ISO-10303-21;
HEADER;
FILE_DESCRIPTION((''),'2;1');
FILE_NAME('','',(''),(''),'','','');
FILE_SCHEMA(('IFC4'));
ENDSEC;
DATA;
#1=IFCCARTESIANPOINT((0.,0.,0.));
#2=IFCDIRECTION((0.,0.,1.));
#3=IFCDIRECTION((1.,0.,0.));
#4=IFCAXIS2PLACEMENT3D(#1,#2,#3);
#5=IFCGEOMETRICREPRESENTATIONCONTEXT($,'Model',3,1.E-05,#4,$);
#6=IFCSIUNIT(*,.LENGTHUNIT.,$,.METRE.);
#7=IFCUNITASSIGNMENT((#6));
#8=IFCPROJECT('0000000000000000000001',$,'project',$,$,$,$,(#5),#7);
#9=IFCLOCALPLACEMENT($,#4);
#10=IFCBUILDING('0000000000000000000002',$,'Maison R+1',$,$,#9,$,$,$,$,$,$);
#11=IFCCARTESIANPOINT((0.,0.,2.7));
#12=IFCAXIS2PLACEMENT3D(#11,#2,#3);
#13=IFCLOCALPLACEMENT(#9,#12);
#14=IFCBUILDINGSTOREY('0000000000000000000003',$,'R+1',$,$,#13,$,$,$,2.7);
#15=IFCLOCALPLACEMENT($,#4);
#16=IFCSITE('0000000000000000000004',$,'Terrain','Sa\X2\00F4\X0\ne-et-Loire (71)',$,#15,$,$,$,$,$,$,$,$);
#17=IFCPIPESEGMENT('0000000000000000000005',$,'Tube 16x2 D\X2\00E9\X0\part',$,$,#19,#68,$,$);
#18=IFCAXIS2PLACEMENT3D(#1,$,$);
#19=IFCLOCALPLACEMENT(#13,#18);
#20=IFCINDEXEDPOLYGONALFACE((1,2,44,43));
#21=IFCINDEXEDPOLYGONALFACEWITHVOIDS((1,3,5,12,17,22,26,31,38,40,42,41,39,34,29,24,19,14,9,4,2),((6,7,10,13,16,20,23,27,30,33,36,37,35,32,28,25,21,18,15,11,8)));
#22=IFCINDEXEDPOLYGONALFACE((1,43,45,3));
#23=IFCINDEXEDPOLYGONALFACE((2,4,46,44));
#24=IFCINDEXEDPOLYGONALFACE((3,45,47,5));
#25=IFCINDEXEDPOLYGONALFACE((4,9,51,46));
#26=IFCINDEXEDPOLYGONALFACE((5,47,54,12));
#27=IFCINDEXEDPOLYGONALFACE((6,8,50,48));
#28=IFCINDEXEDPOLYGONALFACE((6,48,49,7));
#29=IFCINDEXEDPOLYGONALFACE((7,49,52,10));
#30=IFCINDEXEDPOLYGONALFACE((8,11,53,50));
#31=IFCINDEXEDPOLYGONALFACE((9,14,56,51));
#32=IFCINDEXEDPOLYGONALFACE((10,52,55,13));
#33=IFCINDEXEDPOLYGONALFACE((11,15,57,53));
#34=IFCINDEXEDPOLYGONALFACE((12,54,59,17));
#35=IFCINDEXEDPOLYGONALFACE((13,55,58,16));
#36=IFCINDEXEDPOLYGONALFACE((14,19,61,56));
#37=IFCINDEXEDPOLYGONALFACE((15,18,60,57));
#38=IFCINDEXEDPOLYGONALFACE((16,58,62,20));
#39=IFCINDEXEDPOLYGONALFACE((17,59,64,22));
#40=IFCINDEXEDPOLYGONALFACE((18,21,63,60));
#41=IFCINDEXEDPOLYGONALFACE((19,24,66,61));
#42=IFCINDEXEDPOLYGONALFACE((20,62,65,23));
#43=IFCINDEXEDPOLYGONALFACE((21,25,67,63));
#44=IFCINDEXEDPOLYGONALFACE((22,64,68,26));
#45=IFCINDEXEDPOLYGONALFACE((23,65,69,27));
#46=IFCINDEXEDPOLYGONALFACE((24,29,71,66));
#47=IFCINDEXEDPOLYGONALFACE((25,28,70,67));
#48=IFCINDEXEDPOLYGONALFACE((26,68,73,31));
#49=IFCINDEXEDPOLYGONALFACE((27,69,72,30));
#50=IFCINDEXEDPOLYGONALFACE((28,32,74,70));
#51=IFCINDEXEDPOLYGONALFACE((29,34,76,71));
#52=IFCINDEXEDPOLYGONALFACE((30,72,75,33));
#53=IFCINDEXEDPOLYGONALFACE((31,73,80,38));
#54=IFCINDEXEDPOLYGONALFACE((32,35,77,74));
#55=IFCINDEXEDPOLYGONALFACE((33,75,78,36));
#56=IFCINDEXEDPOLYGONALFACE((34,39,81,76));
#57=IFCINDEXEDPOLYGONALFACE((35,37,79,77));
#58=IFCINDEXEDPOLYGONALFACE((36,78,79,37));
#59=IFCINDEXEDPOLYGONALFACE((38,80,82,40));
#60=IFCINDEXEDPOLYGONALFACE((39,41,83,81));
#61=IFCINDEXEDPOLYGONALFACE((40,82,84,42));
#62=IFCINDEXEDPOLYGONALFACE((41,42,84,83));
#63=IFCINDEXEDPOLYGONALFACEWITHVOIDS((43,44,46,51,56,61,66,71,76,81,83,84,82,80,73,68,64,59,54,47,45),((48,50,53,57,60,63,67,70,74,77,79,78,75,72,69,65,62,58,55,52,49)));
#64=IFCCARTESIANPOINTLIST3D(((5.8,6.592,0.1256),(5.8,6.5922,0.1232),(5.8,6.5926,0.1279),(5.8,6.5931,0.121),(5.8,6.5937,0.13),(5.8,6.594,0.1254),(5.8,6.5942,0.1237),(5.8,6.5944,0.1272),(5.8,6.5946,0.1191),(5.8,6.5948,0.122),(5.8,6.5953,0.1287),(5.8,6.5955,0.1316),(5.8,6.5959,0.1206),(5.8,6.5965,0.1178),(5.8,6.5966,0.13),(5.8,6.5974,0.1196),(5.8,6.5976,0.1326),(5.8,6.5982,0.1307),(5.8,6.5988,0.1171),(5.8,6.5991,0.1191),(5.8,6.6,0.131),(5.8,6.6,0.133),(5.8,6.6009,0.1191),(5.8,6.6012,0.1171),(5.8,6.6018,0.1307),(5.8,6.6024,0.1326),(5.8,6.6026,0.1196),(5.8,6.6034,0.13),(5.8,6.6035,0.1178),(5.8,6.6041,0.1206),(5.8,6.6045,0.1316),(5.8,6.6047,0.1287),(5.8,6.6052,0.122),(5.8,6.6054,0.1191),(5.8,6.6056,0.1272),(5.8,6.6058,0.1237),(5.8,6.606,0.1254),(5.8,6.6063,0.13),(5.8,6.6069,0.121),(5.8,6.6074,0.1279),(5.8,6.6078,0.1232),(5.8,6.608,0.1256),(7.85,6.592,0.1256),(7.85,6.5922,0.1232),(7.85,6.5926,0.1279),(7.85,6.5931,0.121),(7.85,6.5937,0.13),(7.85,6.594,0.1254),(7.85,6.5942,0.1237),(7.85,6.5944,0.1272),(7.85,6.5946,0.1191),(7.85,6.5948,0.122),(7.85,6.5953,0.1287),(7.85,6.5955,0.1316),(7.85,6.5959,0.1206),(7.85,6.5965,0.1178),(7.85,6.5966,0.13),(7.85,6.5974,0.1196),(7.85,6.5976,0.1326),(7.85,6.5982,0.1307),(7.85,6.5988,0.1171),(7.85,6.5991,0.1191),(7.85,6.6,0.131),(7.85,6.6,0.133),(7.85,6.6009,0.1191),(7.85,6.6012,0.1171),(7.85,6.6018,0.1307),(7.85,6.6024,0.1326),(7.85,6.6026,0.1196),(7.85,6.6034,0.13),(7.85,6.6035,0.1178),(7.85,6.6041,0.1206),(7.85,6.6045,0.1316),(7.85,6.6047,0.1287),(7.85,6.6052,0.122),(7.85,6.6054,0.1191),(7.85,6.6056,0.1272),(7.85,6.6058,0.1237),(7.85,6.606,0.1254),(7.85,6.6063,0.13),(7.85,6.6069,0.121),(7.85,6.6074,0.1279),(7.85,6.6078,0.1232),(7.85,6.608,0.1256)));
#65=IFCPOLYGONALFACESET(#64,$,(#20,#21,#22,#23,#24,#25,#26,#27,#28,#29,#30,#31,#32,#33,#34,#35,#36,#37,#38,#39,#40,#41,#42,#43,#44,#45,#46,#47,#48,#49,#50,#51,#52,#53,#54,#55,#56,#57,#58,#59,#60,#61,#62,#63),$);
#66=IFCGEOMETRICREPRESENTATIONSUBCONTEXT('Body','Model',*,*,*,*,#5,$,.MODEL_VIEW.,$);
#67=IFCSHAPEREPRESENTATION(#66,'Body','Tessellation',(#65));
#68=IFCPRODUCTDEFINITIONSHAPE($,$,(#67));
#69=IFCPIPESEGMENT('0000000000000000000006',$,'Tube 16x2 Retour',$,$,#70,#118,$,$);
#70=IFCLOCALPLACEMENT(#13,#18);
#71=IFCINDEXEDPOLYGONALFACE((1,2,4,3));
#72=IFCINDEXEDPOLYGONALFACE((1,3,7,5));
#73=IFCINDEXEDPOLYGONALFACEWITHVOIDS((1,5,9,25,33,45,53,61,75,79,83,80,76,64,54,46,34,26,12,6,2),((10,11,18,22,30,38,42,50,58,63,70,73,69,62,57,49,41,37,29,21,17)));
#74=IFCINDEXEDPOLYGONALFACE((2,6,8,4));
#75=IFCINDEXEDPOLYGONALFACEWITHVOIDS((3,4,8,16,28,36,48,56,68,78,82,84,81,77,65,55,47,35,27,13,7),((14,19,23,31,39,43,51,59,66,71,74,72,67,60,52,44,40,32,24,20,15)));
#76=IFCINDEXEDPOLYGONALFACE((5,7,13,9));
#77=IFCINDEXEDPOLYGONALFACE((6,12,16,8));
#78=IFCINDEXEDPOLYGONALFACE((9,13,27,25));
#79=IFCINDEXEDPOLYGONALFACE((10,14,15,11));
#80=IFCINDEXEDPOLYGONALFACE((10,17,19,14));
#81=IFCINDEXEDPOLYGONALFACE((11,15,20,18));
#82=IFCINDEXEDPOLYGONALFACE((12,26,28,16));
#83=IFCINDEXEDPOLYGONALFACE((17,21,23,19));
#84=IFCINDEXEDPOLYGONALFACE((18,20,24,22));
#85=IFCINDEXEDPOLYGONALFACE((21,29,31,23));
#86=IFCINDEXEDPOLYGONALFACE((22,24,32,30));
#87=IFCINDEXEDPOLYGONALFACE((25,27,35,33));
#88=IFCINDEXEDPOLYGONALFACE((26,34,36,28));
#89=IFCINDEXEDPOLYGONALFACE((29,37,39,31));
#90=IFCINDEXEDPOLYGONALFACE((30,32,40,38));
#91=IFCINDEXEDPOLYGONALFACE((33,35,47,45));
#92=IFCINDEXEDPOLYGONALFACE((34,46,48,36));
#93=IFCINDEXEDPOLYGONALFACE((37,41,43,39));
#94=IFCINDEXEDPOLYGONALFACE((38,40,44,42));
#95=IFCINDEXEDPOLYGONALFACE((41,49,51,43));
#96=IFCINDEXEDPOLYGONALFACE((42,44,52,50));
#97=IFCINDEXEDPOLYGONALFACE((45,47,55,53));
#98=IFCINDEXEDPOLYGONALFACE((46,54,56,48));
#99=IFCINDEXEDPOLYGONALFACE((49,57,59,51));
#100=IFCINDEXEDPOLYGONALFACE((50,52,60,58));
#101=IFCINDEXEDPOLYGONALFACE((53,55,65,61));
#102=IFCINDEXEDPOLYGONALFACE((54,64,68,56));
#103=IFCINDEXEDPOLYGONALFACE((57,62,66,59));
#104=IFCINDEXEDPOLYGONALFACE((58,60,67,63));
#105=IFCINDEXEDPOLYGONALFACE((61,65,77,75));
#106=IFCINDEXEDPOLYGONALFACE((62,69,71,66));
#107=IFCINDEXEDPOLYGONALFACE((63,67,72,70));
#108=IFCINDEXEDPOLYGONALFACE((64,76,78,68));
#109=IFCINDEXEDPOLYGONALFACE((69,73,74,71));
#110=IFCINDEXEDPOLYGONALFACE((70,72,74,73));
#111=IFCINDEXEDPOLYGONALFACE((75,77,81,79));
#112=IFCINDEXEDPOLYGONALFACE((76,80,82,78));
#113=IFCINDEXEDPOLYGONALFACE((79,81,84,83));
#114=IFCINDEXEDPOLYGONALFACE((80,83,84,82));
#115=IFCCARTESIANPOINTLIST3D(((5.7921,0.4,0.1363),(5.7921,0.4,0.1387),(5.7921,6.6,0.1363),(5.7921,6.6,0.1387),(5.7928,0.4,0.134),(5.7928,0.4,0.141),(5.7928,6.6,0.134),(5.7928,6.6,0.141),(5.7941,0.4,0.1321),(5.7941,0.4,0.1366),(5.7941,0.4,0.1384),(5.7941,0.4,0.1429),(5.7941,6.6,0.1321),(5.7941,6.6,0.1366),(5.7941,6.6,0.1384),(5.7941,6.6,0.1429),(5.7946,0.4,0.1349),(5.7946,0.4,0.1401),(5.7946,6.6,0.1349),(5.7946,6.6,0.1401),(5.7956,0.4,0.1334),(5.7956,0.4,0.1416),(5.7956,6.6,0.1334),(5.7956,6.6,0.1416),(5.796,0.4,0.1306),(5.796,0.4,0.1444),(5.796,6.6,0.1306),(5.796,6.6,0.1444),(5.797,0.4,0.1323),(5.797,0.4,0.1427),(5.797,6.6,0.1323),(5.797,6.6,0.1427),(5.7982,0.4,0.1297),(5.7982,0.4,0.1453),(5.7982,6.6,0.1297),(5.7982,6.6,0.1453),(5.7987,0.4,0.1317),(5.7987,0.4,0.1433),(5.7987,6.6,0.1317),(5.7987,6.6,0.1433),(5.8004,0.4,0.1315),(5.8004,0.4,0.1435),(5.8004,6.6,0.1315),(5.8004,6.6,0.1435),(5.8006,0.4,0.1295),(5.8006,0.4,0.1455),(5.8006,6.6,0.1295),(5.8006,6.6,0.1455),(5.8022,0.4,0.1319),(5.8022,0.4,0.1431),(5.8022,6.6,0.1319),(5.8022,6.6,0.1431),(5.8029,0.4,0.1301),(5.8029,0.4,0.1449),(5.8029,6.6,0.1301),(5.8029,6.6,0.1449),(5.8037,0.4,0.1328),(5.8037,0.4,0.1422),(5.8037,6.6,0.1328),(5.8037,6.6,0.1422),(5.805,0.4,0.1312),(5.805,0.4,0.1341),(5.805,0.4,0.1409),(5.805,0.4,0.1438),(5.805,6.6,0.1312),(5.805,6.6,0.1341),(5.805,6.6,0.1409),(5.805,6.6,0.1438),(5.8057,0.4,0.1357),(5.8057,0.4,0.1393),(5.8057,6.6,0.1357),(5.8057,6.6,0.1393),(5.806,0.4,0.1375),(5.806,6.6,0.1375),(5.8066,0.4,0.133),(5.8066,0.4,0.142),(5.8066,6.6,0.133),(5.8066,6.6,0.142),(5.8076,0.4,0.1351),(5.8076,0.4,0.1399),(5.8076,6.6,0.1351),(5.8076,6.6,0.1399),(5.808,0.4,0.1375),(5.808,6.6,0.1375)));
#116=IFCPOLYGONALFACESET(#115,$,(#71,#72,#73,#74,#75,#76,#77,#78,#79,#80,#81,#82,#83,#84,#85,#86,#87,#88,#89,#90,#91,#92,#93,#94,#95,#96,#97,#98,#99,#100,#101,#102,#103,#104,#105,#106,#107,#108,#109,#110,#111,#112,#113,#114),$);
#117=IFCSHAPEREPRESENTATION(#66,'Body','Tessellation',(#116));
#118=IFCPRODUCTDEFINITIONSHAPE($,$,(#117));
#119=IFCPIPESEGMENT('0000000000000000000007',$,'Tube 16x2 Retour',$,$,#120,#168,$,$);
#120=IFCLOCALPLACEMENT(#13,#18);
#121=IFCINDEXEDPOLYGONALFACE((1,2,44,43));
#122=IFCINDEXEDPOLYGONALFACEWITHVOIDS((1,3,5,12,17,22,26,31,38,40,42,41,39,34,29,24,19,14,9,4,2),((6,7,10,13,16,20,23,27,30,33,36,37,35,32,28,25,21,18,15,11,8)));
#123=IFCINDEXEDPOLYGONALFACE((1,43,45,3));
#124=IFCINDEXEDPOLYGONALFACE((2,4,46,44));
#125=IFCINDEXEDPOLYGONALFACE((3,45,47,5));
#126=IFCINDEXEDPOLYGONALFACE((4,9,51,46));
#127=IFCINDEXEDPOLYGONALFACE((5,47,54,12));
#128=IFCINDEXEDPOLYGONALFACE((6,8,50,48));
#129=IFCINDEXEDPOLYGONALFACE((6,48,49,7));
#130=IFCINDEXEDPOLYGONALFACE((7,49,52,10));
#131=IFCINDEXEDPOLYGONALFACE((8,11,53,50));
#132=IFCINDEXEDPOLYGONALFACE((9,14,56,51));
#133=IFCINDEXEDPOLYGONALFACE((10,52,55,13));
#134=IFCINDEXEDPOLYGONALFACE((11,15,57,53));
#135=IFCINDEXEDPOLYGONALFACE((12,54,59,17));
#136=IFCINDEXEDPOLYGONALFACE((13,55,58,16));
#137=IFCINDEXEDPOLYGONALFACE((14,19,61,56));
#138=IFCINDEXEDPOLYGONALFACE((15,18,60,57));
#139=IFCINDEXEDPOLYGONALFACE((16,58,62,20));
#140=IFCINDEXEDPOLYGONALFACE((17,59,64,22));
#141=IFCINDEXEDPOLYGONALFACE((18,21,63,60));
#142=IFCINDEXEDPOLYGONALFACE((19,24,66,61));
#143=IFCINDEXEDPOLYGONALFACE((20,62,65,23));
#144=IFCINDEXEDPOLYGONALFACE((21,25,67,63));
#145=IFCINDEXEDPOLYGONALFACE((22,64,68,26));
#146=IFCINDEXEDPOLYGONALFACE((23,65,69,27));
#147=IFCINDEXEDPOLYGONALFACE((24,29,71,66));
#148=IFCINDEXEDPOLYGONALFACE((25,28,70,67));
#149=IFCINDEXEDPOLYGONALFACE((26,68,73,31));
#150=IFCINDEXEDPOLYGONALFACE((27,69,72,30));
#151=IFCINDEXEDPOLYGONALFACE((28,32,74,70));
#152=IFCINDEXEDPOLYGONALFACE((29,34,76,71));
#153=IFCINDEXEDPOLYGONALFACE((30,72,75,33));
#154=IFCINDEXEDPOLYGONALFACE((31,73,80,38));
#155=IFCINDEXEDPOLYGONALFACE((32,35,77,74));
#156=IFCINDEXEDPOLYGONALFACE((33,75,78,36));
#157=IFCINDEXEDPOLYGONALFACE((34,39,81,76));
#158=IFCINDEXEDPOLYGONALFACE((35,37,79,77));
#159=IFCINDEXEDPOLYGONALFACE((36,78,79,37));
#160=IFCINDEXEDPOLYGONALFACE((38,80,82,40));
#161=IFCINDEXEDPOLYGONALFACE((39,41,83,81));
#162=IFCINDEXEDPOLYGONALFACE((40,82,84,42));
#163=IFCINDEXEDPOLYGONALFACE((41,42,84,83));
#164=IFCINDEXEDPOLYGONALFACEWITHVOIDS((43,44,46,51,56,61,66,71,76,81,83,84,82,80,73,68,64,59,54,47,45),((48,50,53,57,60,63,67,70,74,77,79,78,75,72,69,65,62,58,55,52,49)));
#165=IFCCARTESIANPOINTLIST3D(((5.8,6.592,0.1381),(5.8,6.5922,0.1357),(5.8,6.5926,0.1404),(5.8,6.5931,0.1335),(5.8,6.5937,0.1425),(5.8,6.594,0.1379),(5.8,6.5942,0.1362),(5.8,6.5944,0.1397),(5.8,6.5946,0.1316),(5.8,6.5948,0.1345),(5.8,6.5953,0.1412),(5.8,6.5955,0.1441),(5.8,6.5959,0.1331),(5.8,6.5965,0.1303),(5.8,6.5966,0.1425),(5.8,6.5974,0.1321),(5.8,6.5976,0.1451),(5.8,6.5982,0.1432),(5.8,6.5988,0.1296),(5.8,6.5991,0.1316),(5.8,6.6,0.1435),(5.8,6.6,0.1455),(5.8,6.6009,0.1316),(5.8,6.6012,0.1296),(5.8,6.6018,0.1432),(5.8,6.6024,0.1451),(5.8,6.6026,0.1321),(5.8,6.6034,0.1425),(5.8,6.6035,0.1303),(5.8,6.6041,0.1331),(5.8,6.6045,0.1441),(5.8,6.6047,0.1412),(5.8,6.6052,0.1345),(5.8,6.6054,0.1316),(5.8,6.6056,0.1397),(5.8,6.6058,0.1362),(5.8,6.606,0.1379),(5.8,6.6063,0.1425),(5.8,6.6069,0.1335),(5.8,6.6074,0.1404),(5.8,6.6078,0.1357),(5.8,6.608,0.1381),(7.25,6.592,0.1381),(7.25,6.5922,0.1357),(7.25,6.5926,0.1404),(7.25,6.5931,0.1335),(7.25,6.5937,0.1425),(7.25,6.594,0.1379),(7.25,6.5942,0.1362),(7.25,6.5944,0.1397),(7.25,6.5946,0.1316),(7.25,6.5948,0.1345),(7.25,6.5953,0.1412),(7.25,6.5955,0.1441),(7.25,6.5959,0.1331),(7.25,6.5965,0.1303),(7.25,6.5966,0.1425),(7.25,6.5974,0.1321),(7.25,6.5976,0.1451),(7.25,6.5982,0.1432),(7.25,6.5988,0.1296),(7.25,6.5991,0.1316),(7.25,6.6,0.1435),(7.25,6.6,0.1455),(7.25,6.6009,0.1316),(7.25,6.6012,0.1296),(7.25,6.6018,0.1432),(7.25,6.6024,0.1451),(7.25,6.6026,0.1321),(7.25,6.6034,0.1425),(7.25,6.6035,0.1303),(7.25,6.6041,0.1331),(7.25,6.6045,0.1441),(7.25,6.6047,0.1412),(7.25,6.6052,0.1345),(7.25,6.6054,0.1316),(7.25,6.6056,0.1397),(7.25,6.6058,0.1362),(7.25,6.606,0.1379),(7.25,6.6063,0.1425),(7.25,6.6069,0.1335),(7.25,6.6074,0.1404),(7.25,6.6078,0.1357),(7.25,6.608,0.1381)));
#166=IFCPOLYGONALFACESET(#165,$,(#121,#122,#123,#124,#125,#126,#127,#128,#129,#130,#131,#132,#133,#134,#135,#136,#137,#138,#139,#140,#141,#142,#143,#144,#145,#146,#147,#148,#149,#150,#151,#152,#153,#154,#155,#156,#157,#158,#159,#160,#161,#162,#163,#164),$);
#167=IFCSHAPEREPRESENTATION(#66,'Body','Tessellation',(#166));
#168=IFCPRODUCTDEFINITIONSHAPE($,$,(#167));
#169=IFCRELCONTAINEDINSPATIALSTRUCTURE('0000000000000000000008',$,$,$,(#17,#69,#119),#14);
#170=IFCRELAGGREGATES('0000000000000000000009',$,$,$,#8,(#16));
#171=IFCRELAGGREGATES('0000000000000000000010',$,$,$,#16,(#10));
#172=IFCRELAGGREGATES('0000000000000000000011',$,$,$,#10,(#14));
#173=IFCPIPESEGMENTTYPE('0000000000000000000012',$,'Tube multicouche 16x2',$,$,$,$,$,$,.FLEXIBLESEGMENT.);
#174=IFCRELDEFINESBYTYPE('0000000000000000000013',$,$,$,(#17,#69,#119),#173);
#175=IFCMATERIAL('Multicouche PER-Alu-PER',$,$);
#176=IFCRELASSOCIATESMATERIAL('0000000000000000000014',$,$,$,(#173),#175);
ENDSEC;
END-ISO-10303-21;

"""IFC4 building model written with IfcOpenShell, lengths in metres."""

from ifc_helpers import new_model, si_unit, frame, origin_with_axes, place, context, subcontext, project, spatial, hollow_circle, extrude, material, type_object, element, save


model = new_model("IFC4")

# Units and contexts
model_context = context("Model", 3, precision=1e-05, world=origin_with_axes())
body_context = subcontext(model_context, "Body", "Model", "MODEL_VIEW")
ifc_project = project(units=[si_unit("LENGTHUNIT", "METRE")], contexts=[model_context])

# Site, building, storey
site_placement = place(None, origin_with_axes())
site = spatial("IfcSite", under=ifc_project, at=site_placement, Name="Terrain", Description="Saône-et-Loire (71)")
building_placement = place(None, origin_with_axes())
building = spatial("IfcBuilding", under=site, at=building_placement, Name="Maison R+1")
storey_placement = place(building_placement, frame((0.0, 0.0, 2.7), z_axis=(0.0, 0.0, 1.0), x_axis=(1.0, 0.0, 0.0)))
storey = spatial("IfcBuildingStorey", under=building, at=storey_placement, Name="R+1", Elevation=2.7)

# Pipe segments
ifc_material_1 = material(Name="Multicouche PER-Alu-PER")
pipe_segment_type = type_object("IfcPipeSegmentType", Name="Tube multicouche 16x2", PredefinedType="FLEXIBLESEGMENT", material=ifc_material_1)
pipe_segment_1_placement = place(storey_placement, frame((5.8, 6.6, 0.125), z_axis=(1.0, 0.0, 0.0), x_axis=(0.0, 0.0, 1.0)))
element("IfcPipeSegment", 1, at=pipe_segment_1_placement, inside=storey, type_object=pipe_segment_type, Name="Tube 16x2 Départ", context=body_context, shape_type="SweptSolid", body=[
    extrude(hollow_circle(Radius=0.008, WallThickness=0.002), origin_with_axes(), (0.0, 0.0, 1.0), 2.05),
])
pipe_segment_2_placement = place(storey_placement, frame((5.8, 0.4, 0.1375), z_axis=(0.0, 1.0, 0.0), x_axis=(1.0, 0.0, 0.0)))
element("IfcPipeSegment", 2, at=pipe_segment_2_placement, inside=storey, type_object=pipe_segment_type, Name="Tube 16x2 Retour", context=body_context, shape_type="SweptSolid", body=[
    extrude(hollow_circle(Radius=0.008, WallThickness=0.002), origin_with_axes(), (0.0, 0.0, 1.0), 6.2),
])
pipe_segment_3_placement = place(storey_placement, frame((5.8, 6.6, 0.1375), z_axis=(1.0, 0.0, 0.0), x_axis=(0.0, 0.0, 1.0)))
element("IfcPipeSegment", 3, at=pipe_segment_3_placement, inside=storey, type_object=pipe_segment_type, Name="Tube 16x2 Retour", context=body_context, shape_type="SweptSolid", body=[
    extrude(hollow_circle(Radius=0.008, WallThickness=0.002), origin_with_axes(), (0.0, 0.0, 1.0), 1.45),
])

save(model, "model.ifc")
